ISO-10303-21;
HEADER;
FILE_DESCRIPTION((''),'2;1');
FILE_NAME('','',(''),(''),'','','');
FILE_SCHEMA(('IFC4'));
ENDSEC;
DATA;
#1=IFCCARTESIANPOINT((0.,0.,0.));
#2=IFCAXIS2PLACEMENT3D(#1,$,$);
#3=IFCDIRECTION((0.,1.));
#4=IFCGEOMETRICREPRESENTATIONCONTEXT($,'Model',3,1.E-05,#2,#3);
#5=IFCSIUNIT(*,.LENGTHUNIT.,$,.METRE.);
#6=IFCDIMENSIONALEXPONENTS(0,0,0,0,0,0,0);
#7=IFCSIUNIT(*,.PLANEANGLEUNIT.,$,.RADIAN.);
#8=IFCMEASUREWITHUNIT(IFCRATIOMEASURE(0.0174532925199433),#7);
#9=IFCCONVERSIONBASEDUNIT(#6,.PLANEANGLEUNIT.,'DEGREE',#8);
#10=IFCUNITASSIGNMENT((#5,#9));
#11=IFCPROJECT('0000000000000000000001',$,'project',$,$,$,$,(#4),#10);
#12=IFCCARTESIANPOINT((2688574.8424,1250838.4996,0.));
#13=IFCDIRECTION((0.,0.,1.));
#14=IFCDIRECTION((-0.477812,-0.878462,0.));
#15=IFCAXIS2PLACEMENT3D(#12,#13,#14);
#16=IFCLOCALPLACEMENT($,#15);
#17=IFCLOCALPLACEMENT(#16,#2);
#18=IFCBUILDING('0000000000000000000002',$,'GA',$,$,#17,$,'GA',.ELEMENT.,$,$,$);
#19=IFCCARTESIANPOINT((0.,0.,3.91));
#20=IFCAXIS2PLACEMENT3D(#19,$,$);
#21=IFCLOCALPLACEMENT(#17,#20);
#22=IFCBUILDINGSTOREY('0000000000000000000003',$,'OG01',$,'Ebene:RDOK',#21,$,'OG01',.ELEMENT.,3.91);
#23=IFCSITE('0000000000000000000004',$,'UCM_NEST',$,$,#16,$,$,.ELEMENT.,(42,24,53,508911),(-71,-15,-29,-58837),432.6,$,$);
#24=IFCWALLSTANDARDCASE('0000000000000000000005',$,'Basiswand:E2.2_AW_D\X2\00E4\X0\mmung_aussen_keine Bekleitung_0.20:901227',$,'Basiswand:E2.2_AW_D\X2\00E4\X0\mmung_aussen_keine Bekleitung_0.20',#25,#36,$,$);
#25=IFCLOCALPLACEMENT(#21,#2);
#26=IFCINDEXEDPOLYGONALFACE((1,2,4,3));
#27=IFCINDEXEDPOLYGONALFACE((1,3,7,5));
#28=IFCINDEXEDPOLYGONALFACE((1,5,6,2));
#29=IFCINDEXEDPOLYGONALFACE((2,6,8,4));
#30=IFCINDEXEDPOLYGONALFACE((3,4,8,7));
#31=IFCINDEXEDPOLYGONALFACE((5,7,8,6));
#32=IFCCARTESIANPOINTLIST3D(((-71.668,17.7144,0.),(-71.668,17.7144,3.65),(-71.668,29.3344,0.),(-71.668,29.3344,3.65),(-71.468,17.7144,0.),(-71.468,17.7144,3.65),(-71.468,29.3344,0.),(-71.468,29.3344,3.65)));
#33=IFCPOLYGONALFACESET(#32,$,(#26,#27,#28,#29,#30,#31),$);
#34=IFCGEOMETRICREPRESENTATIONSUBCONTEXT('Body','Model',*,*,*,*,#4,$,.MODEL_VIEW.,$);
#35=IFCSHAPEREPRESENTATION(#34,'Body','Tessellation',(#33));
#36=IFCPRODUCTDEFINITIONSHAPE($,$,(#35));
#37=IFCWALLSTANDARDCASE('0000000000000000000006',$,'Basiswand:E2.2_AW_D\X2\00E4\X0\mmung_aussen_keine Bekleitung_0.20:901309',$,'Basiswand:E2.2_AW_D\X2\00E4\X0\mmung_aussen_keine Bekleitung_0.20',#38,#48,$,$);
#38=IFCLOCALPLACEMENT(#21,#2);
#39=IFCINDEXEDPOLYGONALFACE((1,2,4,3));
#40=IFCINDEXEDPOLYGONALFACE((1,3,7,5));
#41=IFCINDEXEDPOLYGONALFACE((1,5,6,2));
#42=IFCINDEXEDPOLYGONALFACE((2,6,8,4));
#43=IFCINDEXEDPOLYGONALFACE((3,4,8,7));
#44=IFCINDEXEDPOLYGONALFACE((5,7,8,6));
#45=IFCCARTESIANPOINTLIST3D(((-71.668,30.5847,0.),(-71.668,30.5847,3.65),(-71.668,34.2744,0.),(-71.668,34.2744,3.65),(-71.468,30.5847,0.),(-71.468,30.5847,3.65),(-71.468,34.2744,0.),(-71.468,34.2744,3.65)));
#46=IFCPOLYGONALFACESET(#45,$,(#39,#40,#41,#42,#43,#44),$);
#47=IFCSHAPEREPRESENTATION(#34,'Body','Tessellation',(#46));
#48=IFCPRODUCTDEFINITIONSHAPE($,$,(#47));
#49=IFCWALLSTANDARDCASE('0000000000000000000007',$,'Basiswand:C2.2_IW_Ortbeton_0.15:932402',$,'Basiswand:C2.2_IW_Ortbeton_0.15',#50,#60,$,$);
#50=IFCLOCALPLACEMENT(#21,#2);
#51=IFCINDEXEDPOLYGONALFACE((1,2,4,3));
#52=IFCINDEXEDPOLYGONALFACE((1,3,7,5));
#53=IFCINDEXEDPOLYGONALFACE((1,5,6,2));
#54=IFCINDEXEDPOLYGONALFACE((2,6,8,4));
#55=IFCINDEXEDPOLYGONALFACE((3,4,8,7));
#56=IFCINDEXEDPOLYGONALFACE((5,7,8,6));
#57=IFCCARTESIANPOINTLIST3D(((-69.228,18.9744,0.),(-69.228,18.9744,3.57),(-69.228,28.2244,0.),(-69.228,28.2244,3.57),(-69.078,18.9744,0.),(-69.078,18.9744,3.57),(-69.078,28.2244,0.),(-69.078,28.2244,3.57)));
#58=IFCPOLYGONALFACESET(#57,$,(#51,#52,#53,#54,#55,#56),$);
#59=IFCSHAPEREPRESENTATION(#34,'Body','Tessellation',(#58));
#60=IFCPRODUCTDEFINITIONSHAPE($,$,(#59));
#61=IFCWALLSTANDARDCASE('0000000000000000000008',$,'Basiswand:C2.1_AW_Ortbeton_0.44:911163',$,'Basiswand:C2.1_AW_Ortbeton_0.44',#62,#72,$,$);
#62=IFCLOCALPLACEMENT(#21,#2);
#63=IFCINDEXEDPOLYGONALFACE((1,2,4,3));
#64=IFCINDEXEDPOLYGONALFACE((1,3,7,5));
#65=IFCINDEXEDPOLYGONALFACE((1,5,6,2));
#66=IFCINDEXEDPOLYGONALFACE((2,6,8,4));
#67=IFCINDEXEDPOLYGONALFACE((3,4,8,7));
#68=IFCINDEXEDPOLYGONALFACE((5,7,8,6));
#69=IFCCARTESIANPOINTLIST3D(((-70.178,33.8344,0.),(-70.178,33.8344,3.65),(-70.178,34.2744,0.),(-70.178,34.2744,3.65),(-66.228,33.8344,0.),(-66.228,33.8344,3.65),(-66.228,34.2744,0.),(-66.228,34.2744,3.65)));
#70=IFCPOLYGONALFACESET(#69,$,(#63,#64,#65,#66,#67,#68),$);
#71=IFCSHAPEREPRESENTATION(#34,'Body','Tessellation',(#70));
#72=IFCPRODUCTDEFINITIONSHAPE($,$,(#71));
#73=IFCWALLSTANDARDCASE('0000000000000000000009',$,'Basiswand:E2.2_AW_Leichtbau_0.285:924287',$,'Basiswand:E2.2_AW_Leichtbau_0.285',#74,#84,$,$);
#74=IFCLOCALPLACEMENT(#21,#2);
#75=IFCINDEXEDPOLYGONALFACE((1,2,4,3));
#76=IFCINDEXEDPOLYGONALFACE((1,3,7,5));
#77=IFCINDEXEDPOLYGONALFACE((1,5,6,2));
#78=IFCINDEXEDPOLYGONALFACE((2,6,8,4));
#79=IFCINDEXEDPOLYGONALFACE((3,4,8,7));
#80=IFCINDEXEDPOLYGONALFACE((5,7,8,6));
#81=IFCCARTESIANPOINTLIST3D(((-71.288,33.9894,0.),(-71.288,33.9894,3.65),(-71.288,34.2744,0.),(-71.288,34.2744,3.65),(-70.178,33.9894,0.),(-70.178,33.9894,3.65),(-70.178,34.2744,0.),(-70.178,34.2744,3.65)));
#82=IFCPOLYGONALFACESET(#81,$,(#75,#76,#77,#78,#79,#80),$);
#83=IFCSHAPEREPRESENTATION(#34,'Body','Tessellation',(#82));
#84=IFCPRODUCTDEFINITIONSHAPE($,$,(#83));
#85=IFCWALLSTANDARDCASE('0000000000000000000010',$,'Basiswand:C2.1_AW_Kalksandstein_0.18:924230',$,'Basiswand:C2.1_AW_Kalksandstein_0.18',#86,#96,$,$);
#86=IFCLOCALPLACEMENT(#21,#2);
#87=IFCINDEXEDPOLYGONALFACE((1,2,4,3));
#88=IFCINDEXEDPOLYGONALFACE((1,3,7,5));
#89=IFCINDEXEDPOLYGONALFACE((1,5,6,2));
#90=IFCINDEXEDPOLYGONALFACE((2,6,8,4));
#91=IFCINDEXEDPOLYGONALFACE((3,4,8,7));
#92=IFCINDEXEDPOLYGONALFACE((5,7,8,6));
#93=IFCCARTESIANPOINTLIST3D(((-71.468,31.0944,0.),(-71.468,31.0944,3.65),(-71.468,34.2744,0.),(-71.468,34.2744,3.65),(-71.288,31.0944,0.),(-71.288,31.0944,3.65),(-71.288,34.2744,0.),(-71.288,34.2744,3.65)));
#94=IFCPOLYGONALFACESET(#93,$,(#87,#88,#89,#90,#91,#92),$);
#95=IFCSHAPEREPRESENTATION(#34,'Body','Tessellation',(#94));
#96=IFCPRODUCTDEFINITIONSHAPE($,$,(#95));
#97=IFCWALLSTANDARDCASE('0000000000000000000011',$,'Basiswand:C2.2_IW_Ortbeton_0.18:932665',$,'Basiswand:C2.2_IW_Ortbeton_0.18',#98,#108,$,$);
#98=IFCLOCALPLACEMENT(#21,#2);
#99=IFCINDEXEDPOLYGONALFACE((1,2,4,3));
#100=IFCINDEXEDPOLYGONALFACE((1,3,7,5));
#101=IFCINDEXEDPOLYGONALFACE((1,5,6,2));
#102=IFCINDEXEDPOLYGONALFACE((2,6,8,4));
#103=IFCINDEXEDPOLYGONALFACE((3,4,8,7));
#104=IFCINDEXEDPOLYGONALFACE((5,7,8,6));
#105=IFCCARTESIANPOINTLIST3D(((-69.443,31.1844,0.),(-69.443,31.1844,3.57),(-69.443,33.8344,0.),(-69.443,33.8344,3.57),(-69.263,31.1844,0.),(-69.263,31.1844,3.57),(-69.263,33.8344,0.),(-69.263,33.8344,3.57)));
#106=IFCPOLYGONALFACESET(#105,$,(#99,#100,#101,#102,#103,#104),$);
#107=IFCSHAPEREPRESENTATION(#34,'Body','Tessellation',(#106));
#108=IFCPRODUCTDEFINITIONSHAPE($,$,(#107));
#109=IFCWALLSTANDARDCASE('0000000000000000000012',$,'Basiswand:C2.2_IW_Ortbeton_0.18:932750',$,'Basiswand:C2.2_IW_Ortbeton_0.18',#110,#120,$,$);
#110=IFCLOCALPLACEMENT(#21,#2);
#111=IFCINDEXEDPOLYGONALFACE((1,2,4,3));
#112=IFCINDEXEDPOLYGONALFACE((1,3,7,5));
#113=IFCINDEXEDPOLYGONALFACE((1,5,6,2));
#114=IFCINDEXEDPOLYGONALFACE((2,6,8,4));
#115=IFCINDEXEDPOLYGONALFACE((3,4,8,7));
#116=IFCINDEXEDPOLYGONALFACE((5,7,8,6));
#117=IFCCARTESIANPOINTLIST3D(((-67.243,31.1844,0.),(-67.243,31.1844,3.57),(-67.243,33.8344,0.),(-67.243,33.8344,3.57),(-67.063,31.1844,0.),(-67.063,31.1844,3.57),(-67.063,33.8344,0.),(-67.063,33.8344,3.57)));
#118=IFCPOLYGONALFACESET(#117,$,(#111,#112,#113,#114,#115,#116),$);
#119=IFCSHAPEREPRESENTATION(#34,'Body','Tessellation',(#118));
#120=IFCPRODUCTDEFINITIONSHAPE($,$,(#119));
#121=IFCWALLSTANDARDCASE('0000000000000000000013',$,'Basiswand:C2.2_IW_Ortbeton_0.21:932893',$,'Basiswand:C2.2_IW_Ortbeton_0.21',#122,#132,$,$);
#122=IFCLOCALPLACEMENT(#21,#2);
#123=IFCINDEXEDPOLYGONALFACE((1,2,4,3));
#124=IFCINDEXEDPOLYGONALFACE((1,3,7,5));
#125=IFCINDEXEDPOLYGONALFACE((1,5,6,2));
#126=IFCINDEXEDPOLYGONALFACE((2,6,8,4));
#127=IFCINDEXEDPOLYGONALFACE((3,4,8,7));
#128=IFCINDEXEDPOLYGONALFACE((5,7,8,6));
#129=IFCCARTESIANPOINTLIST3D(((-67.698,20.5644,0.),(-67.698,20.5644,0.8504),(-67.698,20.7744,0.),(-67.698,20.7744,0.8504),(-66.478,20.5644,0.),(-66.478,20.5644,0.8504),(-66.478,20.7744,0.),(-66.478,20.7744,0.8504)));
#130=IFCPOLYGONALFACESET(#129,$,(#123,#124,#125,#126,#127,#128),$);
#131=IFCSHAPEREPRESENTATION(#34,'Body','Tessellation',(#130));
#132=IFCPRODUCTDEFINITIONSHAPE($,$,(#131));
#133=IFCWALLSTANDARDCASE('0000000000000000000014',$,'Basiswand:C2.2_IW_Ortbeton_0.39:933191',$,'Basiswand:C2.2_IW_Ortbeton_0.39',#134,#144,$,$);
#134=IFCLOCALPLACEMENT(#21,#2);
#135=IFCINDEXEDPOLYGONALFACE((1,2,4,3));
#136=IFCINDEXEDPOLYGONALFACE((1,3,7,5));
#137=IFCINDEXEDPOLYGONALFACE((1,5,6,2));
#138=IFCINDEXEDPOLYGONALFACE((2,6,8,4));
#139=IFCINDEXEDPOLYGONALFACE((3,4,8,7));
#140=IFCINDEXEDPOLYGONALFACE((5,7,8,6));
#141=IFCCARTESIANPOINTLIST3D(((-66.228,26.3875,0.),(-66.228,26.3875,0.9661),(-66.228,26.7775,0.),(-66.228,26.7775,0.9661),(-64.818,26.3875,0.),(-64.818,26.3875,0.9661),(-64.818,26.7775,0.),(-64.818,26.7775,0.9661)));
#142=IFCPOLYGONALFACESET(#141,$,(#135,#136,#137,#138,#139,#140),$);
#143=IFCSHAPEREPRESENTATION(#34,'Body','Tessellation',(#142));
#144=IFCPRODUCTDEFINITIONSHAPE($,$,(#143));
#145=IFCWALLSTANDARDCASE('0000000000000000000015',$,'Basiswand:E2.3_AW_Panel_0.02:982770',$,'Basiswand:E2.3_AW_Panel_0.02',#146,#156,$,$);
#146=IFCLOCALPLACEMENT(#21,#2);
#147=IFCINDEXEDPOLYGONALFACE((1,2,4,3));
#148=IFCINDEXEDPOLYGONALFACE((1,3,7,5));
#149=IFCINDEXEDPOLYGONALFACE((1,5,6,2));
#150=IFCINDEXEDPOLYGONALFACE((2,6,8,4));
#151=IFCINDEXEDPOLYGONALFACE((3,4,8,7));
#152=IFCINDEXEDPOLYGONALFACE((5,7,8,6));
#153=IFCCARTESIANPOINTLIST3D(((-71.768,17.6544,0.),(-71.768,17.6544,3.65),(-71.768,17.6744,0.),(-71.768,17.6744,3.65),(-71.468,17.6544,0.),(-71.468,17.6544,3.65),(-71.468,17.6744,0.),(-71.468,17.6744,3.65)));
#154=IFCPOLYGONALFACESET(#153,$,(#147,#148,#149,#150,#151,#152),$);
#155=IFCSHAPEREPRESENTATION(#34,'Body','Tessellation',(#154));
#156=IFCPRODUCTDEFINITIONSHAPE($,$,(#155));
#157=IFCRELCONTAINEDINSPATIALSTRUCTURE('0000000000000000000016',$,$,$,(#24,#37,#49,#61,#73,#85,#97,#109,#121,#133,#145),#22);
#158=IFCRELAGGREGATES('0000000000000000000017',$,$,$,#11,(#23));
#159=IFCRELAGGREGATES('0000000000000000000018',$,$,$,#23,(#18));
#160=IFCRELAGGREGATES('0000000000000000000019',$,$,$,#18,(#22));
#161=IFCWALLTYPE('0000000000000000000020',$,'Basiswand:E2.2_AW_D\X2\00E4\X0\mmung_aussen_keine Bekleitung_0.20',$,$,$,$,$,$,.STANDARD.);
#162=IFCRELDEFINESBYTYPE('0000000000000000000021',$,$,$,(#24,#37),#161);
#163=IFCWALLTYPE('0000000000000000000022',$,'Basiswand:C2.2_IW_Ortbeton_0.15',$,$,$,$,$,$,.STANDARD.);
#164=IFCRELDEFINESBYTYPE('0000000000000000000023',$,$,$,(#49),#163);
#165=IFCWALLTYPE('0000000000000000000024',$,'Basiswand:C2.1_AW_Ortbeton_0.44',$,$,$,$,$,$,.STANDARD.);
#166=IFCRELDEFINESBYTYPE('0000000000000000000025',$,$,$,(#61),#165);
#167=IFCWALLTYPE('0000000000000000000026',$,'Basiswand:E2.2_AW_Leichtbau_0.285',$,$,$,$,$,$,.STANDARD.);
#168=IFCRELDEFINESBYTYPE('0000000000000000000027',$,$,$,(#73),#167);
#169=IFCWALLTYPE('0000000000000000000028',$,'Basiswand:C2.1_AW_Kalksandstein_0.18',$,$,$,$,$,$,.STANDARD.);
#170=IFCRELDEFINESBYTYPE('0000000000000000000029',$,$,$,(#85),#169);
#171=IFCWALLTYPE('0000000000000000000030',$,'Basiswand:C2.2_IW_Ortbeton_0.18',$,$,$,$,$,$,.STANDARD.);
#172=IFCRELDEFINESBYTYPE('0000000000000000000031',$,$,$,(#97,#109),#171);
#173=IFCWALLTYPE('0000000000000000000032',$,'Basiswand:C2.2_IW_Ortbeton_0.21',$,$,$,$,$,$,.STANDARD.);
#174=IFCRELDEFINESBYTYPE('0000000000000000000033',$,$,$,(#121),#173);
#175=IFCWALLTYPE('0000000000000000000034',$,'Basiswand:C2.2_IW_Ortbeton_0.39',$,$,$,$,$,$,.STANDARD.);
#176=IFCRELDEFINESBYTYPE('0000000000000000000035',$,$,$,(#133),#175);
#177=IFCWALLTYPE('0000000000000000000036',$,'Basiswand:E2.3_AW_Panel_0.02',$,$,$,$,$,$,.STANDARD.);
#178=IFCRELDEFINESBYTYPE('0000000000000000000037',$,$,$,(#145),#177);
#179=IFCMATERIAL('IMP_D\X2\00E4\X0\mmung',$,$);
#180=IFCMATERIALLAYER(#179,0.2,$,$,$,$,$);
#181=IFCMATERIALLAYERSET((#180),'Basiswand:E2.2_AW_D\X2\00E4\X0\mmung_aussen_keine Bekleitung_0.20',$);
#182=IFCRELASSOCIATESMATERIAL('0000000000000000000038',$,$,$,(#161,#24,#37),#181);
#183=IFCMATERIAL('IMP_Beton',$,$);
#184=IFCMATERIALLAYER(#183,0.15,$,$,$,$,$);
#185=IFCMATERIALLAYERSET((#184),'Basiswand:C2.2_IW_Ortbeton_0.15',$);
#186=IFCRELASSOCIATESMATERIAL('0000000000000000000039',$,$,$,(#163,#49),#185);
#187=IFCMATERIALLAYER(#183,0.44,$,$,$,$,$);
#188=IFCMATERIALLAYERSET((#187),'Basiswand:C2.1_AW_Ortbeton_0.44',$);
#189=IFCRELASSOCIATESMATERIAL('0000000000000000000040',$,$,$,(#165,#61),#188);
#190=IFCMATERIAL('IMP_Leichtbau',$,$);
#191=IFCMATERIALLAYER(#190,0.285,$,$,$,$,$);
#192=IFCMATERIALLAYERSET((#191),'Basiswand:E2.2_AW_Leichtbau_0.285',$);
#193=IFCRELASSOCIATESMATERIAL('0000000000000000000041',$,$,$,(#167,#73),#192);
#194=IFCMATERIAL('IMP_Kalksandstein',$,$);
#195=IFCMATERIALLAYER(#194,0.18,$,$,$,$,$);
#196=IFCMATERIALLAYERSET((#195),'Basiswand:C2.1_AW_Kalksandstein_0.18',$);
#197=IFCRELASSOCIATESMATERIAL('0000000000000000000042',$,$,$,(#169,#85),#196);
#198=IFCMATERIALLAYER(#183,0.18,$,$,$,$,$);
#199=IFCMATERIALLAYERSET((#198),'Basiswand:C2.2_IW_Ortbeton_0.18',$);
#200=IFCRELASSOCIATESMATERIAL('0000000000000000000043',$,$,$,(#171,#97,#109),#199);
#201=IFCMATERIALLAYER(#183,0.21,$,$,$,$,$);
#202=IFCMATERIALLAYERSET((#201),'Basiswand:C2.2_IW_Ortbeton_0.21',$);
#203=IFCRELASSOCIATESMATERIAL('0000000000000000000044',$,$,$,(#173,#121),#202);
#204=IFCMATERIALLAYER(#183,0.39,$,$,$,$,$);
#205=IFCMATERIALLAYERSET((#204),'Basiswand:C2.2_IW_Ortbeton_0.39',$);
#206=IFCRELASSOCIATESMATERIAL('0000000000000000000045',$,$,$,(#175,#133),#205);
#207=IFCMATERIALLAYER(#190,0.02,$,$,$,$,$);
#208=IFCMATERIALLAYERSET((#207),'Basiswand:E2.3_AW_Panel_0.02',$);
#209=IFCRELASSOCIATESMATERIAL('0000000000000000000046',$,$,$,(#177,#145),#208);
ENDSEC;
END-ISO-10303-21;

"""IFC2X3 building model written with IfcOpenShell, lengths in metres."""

from ifc_helpers import new_model, entity, si_unit, converted_unit, direction, frame, frame_2d, origin, place, context, subcontext, project, spatial, polyline, rectangle, extrude, clip, bounded_halfspace, material, layer, layer_set, layer_usage, type_object, element, save


model = new_model("IFC2X3")

# Units and contexts
model_context = context("Model", 3, precision=1e-05, world=origin(), true_north=direction((0.0, 1.0)))
body_context = subcontext(model_context, "Body", "Model", "MODEL_VIEW")
ifc_project = project(units=[si_unit("LENGTHUNIT", "METRE"), converted_unit("PLANEANGLEUNIT", "DEGREE", entity("IfcRatioMeasure", 0.0174532925199433), si_unit("PLANEANGLEUNIT", "RADIAN"), dimensions=[0, 0, 0, 0, 0, 0, 0])], contexts=[model_context])

# Site, building, storey
site_placement = place(None, frame((2688574.8424, 1250838.4996, 0.0), z_axis=(0.0, 0.0, 1.0), x_axis=(-0.477812, -0.878462, 0.0)))
site = spatial("IfcSite", under=ifc_project, at=site_placement, Name="UCM_NEST", CompositionType="ELEMENT", RefLatitude=(42, 24, 53, 508911), RefLongitude=(-71, -15, -29, -58837), RefElevation=432.6)
building_placement = place(site_placement, origin())
building = spatial("IfcBuilding", under=site, at=building_placement, Name="GA", LongName="GA", CompositionType="ELEMENT")
storey_placement = place(building_placement, frame((0.0, 0.0, 3.91)))
storey = spatial("IfcBuildingStorey", under=building, at=storey_placement, Name="OG01", ObjectType="Ebene:RDOK", LongName="OG01", CompositionType="ELEMENT", Elevation=3.91)

# Walls
ifc_material_1 = material(Name="IMP_Dämmung")
ifc_layer_1 = layer(ifc_material_1, 0.2)
ifc_layer_set_1 = layer_set([ifc_layer_1], Name="Basiswand:E2.2_AW_Dämmung_aussen_keine Bekleitung_0.20")
ifc_layer_usage_1 = layer_usage(ifc_layer_set_1, "AXIS2", "NEGATIVE", 0.1)
wall_type_1 = type_object("IfcWallType", Name="Basiswand:E2.2_AW_Dämmung_aussen_keine Bekleitung_0.20", PredefinedType="STANDARD", material=ifc_layer_set_1)
wall_1_placement = place(storey_placement, frame((-71.568, 17.7144, 0.0), z_axis=(0.0, 0.0, 1.0), x_axis=(0.0, 1.0, 0.0)))
element("IfcWallStandardCase", 1, at=wall_1_placement, inside=storey, type_object=wall_type_1, material=ifc_layer_usage_1, Name="Basiswand:E2.2_AW_Dämmung_aussen_keine Bekleitung_0.20:901227", ObjectType="Basiswand:E2.2_AW_Dämmung_aussen_keine Bekleitung_0.20", context=body_context, shape_type="SweptSolid", body=[
    extrude(rectangle(XDim=11.62, YDim=0.2, at=frame_2d((5.81, 0.0), x_axis=(-1.0, 0.0))), origin(), (0.0, 0.0, 1.0), 3.65),
])
ifc_layer_usage_2 = layer_usage(ifc_layer_set_1, "AXIS2", "NEGATIVE", 0.1)
wall_2_placement = place(storey_placement, frame((-71.568, 30.5847, 0.0), z_axis=(0.0, 0.0, 1.0), x_axis=(0.0, 1.0, 0.0)))
element("IfcWallStandardCase", 2, at=wall_2_placement, inside=storey, type_object=wall_type_1, material=ifc_layer_usage_2, Name="Basiswand:E2.2_AW_Dämmung_aussen_keine Bekleitung_0.20:901309", ObjectType="Basiswand:E2.2_AW_Dämmung_aussen_keine Bekleitung_0.20", context=body_context, shape_type="SweptSolid", body=[
    extrude(rectangle(XDim=3.6898, YDim=0.2, at=frame_2d((1.8449, 0.0), x_axis=(-1.0, 0.0))), origin(), (0.0, 0.0, 1.0), 3.65),
])

# Shared definitions
ifc_material_2 = material(Name="IMP_Beton")
ifc_layer_2 = layer(ifc_material_2, 0.15)
ifc_layer_set_2 = layer_set([ifc_layer_2], Name="Basiswand:C2.2_IW_Ortbeton_0.15")
wall_type_2 = type_object("IfcWallType", Name="Basiswand:C2.2_IW_Ortbeton_0.15", PredefinedType="STANDARD", material=ifc_layer_set_2)

# Wall
ifc_layer_usage_3 = layer_usage(ifc_layer_set_2, "AXIS2", "NEGATIVE", 0.075)
wall_3_placement = place(storey_placement, frame((-69.153, 18.9744, 0.0), z_axis=(0.0, 0.0, 1.0), x_axis=(0.0, 1.0, 0.0)))
element("IfcWallStandardCase", 3, at=wall_3_placement, inside=storey, type_object=wall_type_2, material=ifc_layer_usage_3, Name="Basiswand:C2.2_IW_Ortbeton_0.15:932402", ObjectType="Basiswand:C2.2_IW_Ortbeton_0.15", context=body_context, shape_type="Clipping", body=[
    clip(extrude(rectangle(XDim=9.25, YDim=0.15, at=frame_2d((4.625, 0.0), x_axis=(-1.0, 0.0))), origin(), (0.0, 0.0, 1.0), 3.57), bounded_halfspace(frame((0.0, -0.075, 3.57), z_axis=(0.0, 0.0, -1.0), x_axis=(-1.0, 0.0, 0.0)), True, frame((0.0, -0.075, 3.57), z_axis=(0.0, 0.0, -1.0), x_axis=(-1.0, 0.0, 0.0)), polyline([(0.0, 0.0), (0.0, 0.15), (-9.1, 0.15), (-9.25, 0.15), (-9.25, 0.0), (0.0, 0.0)]))),
])

# Wall
ifc_layer_3 = layer(ifc_material_2, 0.44)
ifc_layer_set_3 = layer_set([ifc_layer_3], Name="Basiswand:C2.1_AW_Ortbeton_0.44")
ifc_layer_usage_4 = layer_usage(ifc_layer_set_3, "AXIS2", "NEGATIVE", 0.22)
wall_type_3 = type_object("IfcWallType", Name="Basiswand:C2.1_AW_Ortbeton_0.44", PredefinedType="STANDARD", material=ifc_layer_set_3)
wall_4_placement = place(storey_placement, frame((-70.178, 34.0544, 0.0)))
element("IfcWallStandardCase", 4, at=wall_4_placement, inside=storey, type_object=wall_type_3, material=ifc_layer_usage_4, Name="Basiswand:C2.1_AW_Ortbeton_0.44:911163", ObjectType="Basiswand:C2.1_AW_Ortbeton_0.44", context=body_context, shape_type="SweptSolid", body=[
    extrude(rectangle(XDim=3.95, YDim=0.44, at=frame_2d((1.975, 0.0), x_axis=(-1.0, 0.0))), origin(), (0.0, 0.0, 1.0), 3.65),
])

# Wall
ifc_material_3 = material(Name="IMP_Leichtbau")
ifc_layer_4 = layer(ifc_material_3, 0.285)
ifc_layer_set_4 = layer_set([ifc_layer_4], Name="Basiswand:E2.2_AW_Leichtbau_0.285")
ifc_layer_usage_5 = layer_usage(ifc_layer_set_4, "AXIS2", "NEGATIVE", 0.1425)
wall_type_4 = type_object("IfcWallType", Name="Basiswand:E2.2_AW_Leichtbau_0.285", PredefinedType="STANDARD", material=ifc_layer_set_4)
wall_5_placement = place(storey_placement, frame((-71.288, 34.1319, 0.0)))
element("IfcWallStandardCase", 5, at=wall_5_placement, inside=storey, type_object=wall_type_4, material=ifc_layer_usage_5, Name="Basiswand:E2.2_AW_Leichtbau_0.285:924287", ObjectType="Basiswand:E2.2_AW_Leichtbau_0.285", context=body_context, shape_type="SweptSolid", body=[
    extrude(rectangle(XDim=1.11, YDim=0.285, at=frame_2d((0.555, 0.0), x_axis=(-1.0, 0.0))), origin(), (0.0, 0.0, 1.0), 3.65),
])

# Shared definitions
ifc_material_4 = material(Name="IMP_Kalksandstein")
ifc_layer_5 = layer(ifc_material_4, 0.18)
ifc_layer_set_5 = layer_set([ifc_layer_5], Name="Basiswand:C2.1_AW_Kalksandstein_0.18")
wall_type_5 = type_object("IfcWallType", Name="Basiswand:C2.1_AW_Kalksandstein_0.18", PredefinedType="STANDARD", material=ifc_layer_set_5)

# Wall
ifc_layer_usage_6 = layer_usage(ifc_layer_set_5, "AXIS2", "NEGATIVE", 0.09)
wall_6_placement = place(storey_placement, frame((-71.378, 31.0944, 0.0), z_axis=(0.0, 0.0, 1.0), x_axis=(0.0, 1.0, 0.0)))
element("IfcWallStandardCase", 6, at=wall_6_placement, inside=storey, type_object=wall_type_5, material=ifc_layer_usage_6, Name="Basiswand:C2.1_AW_Kalksandstein_0.18:924230", ObjectType="Basiswand:C2.1_AW_Kalksandstein_0.18", context=body_context, shape_type="SweptSolid", body=[
    extrude(rectangle(XDim=3.18, YDim=0.18, at=frame_2d((1.59, 0.0), x_axis=(-1.0, 0.0))), origin(), (0.0, 0.0, 1.0), 3.65),
])

# Shared definitions
ifc_layer_6 = layer(ifc_material_2, 0.18)
ifc_layer_set_6 = layer_set([ifc_layer_6], Name="Basiswand:C2.2_IW_Ortbeton_0.18")
wall_type_6 = type_object("IfcWallType", Name="Basiswand:C2.2_IW_Ortbeton_0.18", PredefinedType="STANDARD", material=ifc_layer_set_6)

# Walls
ifc_layer_usage_7 = layer_usage(ifc_layer_set_6, "AXIS2", "NEGATIVE", 0.09)
wall_7_placement = place(storey_placement, frame((-69.353, 31.1844, 0.0), z_axis=(0.0, 0.0, 1.0), x_axis=(0.0, 1.0, 0.0)))
element("IfcWallStandardCase", 7, at=wall_7_placement, inside=storey, type_object=wall_type_6, material=ifc_layer_usage_7, Name="Basiswand:C2.2_IW_Ortbeton_0.18:932665", ObjectType="Basiswand:C2.2_IW_Ortbeton_0.18", context=body_context, shape_type="Clipping", body=[
    clip(extrude(rectangle(XDim=2.65, YDim=0.18, at=frame_2d((1.325, 0.0), x_axis=(-1.0, 0.0))), origin(), (0.0, 0.0, 1.0), 3.57), bounded_halfspace(frame((0.0, -0.09, 3.57), z_axis=(0.0, 0.0, -1.0), x_axis=(-1.0, 0.0, 0.0)), True, frame((0.0, -0.09, 3.57), z_axis=(0.0, 0.0, -1.0), x_axis=(-1.0, 0.0, 0.0)), polyline([(0.0, 0.0), (0.0, 0.18), (-2.65, 0.18), (-2.65, 0.0), (0.0, 0.0)]))),
])
ifc_layer_usage_8 = layer_usage(ifc_layer_set_6, "AXIS2", "NEGATIVE", 0.09)
wall_8_placement = place(storey_placement, frame((-67.153, 31.1844, 0.0), z_axis=(0.0, 0.0, 1.0), x_axis=(0.0, 1.0, 0.0)))
element("IfcWallStandardCase", 8, at=wall_8_placement, inside=storey, type_object=wall_type_6, material=ifc_layer_usage_8, Name="Basiswand:C2.2_IW_Ortbeton_0.18:932750", ObjectType="Basiswand:C2.2_IW_Ortbeton_0.18", context=body_context, shape_type="Clipping", body=[
    clip(extrude(rectangle(XDim=2.65, YDim=0.18, at=frame_2d((1.325, 0.0), x_axis=(-1.0, 0.0))), origin(), (0.0, 0.0, 1.0), 3.57), bounded_halfspace(frame((0.0, -0.09, 3.57), z_axis=(0.0, 0.0, -1.0), x_axis=(-1.0, 0.0, 0.0)), True, frame((0.0, -0.09, 3.57), z_axis=(0.0, 0.0, -1.0), x_axis=(-1.0, 0.0, 0.0)), polyline([(0.0, 0.0), (0.0, 0.18), (-2.65, 0.18), (-2.65, 0.0), (0.0, 0.0)]))),
])

# Walls
ifc_layer_7 = layer(ifc_material_2, 0.21)
ifc_layer_set_7 = layer_set([ifc_layer_7], Name="Basiswand:C2.2_IW_Ortbeton_0.21")
ifc_layer_usage_9 = layer_usage(ifc_layer_set_7, "AXIS2", "NEGATIVE", 0.105)
wall_type_7 = type_object("IfcWallType", Name="Basiswand:C2.2_IW_Ortbeton_0.21", PredefinedType="STANDARD", material=ifc_layer_set_7)
wall_9_placement = place(storey_placement, frame((-66.478, 20.6694, 0.0), z_axis=(0.0, 0.0, 1.0), x_axis=(-1.0, 0.0, 0.0)))
element("IfcWallStandardCase", 9, at=wall_9_placement, inside=storey, type_object=wall_type_7, material=ifc_layer_usage_9, Name="Basiswand:C2.2_IW_Ortbeton_0.21:932893", ObjectType="Basiswand:C2.2_IW_Ortbeton_0.21", context=body_context, shape_type="SweptSolid", body=[
    extrude(rectangle(XDim=1.22, YDim=0.21, at=frame_2d((0.61, 0.0), x_axis=(-1.0, 0.0))), origin(), (0.0, 0.0, 1.0), 0.8504),
])
ifc_layer_8 = layer(ifc_material_2, 0.39)
ifc_layer_set_8 = layer_set([ifc_layer_8], Name="Basiswand:C2.2_IW_Ortbeton_0.39")
ifc_layer_usage_10 = layer_usage(ifc_layer_set_8, "AXIS2", "NEGATIVE", 0.195)
wall_type_8 = type_object("IfcWallType", Name="Basiswand:C2.2_IW_Ortbeton_0.39", PredefinedType="STANDARD", material=ifc_layer_set_8)
wall_10_placement = place(storey_placement, frame((-64.818, 26.5825, 0.0), z_axis=(0.0, 0.0, 1.0), x_axis=(-1.0, 0.0, 0.0)))
element("IfcWallStandardCase", 10, at=wall_10_placement, inside=storey, type_object=wall_type_8, material=ifc_layer_usage_10, Name="Basiswand:C2.2_IW_Ortbeton_0.39:933191", ObjectType="Basiswand:C2.2_IW_Ortbeton_0.39", context=body_context, shape_type="SweptSolid", body=[
    extrude(rectangle(XDim=1.41, YDim=0.39, at=frame_2d((0.705, 0.0), x_axis=(-1.0, 0.0))), origin(), (0.0, 0.0, 1.0), 0.9661),
])
ifc_layer_9 = layer(ifc_material_3, 0.02)
ifc_layer_set_9 = layer_set([ifc_layer_9], Name="Basiswand:E2.3_AW_Panel_0.02")
ifc_layer_usage_11 = layer_usage(ifc_layer_set_9, "AXIS2", "NEGATIVE", 0.01)
wall_type_9 = type_object("IfcWallType", Name="Basiswand:E2.3_AW_Panel_0.02", PredefinedType="STANDARD", material=ifc_layer_set_9)
wall_11_placement = place(storey_placement, frame((-71.468, 17.6644, 0.0), z_axis=(0.0, 0.0, 1.0), x_axis=(-1.0, 0.0, 0.0)))
element("IfcWallStandardCase", 11, at=wall_11_placement, inside=storey, type_object=wall_type_9, material=ifc_layer_usage_11, Name="Basiswand:E2.3_AW_Panel_0.02:982770", ObjectType="Basiswand:E2.3_AW_Panel_0.02", context=body_context, shape_type="SweptSolid", body=[
    extrude(rectangle(XDim=0.3, YDim=0.02, at=frame_2d((0.15, 0.0), x_axis=(-1.0, 0.0))), origin(), (0.0, 0.0, 1.0), 3.65),
])

save(model, "model.ifc")
